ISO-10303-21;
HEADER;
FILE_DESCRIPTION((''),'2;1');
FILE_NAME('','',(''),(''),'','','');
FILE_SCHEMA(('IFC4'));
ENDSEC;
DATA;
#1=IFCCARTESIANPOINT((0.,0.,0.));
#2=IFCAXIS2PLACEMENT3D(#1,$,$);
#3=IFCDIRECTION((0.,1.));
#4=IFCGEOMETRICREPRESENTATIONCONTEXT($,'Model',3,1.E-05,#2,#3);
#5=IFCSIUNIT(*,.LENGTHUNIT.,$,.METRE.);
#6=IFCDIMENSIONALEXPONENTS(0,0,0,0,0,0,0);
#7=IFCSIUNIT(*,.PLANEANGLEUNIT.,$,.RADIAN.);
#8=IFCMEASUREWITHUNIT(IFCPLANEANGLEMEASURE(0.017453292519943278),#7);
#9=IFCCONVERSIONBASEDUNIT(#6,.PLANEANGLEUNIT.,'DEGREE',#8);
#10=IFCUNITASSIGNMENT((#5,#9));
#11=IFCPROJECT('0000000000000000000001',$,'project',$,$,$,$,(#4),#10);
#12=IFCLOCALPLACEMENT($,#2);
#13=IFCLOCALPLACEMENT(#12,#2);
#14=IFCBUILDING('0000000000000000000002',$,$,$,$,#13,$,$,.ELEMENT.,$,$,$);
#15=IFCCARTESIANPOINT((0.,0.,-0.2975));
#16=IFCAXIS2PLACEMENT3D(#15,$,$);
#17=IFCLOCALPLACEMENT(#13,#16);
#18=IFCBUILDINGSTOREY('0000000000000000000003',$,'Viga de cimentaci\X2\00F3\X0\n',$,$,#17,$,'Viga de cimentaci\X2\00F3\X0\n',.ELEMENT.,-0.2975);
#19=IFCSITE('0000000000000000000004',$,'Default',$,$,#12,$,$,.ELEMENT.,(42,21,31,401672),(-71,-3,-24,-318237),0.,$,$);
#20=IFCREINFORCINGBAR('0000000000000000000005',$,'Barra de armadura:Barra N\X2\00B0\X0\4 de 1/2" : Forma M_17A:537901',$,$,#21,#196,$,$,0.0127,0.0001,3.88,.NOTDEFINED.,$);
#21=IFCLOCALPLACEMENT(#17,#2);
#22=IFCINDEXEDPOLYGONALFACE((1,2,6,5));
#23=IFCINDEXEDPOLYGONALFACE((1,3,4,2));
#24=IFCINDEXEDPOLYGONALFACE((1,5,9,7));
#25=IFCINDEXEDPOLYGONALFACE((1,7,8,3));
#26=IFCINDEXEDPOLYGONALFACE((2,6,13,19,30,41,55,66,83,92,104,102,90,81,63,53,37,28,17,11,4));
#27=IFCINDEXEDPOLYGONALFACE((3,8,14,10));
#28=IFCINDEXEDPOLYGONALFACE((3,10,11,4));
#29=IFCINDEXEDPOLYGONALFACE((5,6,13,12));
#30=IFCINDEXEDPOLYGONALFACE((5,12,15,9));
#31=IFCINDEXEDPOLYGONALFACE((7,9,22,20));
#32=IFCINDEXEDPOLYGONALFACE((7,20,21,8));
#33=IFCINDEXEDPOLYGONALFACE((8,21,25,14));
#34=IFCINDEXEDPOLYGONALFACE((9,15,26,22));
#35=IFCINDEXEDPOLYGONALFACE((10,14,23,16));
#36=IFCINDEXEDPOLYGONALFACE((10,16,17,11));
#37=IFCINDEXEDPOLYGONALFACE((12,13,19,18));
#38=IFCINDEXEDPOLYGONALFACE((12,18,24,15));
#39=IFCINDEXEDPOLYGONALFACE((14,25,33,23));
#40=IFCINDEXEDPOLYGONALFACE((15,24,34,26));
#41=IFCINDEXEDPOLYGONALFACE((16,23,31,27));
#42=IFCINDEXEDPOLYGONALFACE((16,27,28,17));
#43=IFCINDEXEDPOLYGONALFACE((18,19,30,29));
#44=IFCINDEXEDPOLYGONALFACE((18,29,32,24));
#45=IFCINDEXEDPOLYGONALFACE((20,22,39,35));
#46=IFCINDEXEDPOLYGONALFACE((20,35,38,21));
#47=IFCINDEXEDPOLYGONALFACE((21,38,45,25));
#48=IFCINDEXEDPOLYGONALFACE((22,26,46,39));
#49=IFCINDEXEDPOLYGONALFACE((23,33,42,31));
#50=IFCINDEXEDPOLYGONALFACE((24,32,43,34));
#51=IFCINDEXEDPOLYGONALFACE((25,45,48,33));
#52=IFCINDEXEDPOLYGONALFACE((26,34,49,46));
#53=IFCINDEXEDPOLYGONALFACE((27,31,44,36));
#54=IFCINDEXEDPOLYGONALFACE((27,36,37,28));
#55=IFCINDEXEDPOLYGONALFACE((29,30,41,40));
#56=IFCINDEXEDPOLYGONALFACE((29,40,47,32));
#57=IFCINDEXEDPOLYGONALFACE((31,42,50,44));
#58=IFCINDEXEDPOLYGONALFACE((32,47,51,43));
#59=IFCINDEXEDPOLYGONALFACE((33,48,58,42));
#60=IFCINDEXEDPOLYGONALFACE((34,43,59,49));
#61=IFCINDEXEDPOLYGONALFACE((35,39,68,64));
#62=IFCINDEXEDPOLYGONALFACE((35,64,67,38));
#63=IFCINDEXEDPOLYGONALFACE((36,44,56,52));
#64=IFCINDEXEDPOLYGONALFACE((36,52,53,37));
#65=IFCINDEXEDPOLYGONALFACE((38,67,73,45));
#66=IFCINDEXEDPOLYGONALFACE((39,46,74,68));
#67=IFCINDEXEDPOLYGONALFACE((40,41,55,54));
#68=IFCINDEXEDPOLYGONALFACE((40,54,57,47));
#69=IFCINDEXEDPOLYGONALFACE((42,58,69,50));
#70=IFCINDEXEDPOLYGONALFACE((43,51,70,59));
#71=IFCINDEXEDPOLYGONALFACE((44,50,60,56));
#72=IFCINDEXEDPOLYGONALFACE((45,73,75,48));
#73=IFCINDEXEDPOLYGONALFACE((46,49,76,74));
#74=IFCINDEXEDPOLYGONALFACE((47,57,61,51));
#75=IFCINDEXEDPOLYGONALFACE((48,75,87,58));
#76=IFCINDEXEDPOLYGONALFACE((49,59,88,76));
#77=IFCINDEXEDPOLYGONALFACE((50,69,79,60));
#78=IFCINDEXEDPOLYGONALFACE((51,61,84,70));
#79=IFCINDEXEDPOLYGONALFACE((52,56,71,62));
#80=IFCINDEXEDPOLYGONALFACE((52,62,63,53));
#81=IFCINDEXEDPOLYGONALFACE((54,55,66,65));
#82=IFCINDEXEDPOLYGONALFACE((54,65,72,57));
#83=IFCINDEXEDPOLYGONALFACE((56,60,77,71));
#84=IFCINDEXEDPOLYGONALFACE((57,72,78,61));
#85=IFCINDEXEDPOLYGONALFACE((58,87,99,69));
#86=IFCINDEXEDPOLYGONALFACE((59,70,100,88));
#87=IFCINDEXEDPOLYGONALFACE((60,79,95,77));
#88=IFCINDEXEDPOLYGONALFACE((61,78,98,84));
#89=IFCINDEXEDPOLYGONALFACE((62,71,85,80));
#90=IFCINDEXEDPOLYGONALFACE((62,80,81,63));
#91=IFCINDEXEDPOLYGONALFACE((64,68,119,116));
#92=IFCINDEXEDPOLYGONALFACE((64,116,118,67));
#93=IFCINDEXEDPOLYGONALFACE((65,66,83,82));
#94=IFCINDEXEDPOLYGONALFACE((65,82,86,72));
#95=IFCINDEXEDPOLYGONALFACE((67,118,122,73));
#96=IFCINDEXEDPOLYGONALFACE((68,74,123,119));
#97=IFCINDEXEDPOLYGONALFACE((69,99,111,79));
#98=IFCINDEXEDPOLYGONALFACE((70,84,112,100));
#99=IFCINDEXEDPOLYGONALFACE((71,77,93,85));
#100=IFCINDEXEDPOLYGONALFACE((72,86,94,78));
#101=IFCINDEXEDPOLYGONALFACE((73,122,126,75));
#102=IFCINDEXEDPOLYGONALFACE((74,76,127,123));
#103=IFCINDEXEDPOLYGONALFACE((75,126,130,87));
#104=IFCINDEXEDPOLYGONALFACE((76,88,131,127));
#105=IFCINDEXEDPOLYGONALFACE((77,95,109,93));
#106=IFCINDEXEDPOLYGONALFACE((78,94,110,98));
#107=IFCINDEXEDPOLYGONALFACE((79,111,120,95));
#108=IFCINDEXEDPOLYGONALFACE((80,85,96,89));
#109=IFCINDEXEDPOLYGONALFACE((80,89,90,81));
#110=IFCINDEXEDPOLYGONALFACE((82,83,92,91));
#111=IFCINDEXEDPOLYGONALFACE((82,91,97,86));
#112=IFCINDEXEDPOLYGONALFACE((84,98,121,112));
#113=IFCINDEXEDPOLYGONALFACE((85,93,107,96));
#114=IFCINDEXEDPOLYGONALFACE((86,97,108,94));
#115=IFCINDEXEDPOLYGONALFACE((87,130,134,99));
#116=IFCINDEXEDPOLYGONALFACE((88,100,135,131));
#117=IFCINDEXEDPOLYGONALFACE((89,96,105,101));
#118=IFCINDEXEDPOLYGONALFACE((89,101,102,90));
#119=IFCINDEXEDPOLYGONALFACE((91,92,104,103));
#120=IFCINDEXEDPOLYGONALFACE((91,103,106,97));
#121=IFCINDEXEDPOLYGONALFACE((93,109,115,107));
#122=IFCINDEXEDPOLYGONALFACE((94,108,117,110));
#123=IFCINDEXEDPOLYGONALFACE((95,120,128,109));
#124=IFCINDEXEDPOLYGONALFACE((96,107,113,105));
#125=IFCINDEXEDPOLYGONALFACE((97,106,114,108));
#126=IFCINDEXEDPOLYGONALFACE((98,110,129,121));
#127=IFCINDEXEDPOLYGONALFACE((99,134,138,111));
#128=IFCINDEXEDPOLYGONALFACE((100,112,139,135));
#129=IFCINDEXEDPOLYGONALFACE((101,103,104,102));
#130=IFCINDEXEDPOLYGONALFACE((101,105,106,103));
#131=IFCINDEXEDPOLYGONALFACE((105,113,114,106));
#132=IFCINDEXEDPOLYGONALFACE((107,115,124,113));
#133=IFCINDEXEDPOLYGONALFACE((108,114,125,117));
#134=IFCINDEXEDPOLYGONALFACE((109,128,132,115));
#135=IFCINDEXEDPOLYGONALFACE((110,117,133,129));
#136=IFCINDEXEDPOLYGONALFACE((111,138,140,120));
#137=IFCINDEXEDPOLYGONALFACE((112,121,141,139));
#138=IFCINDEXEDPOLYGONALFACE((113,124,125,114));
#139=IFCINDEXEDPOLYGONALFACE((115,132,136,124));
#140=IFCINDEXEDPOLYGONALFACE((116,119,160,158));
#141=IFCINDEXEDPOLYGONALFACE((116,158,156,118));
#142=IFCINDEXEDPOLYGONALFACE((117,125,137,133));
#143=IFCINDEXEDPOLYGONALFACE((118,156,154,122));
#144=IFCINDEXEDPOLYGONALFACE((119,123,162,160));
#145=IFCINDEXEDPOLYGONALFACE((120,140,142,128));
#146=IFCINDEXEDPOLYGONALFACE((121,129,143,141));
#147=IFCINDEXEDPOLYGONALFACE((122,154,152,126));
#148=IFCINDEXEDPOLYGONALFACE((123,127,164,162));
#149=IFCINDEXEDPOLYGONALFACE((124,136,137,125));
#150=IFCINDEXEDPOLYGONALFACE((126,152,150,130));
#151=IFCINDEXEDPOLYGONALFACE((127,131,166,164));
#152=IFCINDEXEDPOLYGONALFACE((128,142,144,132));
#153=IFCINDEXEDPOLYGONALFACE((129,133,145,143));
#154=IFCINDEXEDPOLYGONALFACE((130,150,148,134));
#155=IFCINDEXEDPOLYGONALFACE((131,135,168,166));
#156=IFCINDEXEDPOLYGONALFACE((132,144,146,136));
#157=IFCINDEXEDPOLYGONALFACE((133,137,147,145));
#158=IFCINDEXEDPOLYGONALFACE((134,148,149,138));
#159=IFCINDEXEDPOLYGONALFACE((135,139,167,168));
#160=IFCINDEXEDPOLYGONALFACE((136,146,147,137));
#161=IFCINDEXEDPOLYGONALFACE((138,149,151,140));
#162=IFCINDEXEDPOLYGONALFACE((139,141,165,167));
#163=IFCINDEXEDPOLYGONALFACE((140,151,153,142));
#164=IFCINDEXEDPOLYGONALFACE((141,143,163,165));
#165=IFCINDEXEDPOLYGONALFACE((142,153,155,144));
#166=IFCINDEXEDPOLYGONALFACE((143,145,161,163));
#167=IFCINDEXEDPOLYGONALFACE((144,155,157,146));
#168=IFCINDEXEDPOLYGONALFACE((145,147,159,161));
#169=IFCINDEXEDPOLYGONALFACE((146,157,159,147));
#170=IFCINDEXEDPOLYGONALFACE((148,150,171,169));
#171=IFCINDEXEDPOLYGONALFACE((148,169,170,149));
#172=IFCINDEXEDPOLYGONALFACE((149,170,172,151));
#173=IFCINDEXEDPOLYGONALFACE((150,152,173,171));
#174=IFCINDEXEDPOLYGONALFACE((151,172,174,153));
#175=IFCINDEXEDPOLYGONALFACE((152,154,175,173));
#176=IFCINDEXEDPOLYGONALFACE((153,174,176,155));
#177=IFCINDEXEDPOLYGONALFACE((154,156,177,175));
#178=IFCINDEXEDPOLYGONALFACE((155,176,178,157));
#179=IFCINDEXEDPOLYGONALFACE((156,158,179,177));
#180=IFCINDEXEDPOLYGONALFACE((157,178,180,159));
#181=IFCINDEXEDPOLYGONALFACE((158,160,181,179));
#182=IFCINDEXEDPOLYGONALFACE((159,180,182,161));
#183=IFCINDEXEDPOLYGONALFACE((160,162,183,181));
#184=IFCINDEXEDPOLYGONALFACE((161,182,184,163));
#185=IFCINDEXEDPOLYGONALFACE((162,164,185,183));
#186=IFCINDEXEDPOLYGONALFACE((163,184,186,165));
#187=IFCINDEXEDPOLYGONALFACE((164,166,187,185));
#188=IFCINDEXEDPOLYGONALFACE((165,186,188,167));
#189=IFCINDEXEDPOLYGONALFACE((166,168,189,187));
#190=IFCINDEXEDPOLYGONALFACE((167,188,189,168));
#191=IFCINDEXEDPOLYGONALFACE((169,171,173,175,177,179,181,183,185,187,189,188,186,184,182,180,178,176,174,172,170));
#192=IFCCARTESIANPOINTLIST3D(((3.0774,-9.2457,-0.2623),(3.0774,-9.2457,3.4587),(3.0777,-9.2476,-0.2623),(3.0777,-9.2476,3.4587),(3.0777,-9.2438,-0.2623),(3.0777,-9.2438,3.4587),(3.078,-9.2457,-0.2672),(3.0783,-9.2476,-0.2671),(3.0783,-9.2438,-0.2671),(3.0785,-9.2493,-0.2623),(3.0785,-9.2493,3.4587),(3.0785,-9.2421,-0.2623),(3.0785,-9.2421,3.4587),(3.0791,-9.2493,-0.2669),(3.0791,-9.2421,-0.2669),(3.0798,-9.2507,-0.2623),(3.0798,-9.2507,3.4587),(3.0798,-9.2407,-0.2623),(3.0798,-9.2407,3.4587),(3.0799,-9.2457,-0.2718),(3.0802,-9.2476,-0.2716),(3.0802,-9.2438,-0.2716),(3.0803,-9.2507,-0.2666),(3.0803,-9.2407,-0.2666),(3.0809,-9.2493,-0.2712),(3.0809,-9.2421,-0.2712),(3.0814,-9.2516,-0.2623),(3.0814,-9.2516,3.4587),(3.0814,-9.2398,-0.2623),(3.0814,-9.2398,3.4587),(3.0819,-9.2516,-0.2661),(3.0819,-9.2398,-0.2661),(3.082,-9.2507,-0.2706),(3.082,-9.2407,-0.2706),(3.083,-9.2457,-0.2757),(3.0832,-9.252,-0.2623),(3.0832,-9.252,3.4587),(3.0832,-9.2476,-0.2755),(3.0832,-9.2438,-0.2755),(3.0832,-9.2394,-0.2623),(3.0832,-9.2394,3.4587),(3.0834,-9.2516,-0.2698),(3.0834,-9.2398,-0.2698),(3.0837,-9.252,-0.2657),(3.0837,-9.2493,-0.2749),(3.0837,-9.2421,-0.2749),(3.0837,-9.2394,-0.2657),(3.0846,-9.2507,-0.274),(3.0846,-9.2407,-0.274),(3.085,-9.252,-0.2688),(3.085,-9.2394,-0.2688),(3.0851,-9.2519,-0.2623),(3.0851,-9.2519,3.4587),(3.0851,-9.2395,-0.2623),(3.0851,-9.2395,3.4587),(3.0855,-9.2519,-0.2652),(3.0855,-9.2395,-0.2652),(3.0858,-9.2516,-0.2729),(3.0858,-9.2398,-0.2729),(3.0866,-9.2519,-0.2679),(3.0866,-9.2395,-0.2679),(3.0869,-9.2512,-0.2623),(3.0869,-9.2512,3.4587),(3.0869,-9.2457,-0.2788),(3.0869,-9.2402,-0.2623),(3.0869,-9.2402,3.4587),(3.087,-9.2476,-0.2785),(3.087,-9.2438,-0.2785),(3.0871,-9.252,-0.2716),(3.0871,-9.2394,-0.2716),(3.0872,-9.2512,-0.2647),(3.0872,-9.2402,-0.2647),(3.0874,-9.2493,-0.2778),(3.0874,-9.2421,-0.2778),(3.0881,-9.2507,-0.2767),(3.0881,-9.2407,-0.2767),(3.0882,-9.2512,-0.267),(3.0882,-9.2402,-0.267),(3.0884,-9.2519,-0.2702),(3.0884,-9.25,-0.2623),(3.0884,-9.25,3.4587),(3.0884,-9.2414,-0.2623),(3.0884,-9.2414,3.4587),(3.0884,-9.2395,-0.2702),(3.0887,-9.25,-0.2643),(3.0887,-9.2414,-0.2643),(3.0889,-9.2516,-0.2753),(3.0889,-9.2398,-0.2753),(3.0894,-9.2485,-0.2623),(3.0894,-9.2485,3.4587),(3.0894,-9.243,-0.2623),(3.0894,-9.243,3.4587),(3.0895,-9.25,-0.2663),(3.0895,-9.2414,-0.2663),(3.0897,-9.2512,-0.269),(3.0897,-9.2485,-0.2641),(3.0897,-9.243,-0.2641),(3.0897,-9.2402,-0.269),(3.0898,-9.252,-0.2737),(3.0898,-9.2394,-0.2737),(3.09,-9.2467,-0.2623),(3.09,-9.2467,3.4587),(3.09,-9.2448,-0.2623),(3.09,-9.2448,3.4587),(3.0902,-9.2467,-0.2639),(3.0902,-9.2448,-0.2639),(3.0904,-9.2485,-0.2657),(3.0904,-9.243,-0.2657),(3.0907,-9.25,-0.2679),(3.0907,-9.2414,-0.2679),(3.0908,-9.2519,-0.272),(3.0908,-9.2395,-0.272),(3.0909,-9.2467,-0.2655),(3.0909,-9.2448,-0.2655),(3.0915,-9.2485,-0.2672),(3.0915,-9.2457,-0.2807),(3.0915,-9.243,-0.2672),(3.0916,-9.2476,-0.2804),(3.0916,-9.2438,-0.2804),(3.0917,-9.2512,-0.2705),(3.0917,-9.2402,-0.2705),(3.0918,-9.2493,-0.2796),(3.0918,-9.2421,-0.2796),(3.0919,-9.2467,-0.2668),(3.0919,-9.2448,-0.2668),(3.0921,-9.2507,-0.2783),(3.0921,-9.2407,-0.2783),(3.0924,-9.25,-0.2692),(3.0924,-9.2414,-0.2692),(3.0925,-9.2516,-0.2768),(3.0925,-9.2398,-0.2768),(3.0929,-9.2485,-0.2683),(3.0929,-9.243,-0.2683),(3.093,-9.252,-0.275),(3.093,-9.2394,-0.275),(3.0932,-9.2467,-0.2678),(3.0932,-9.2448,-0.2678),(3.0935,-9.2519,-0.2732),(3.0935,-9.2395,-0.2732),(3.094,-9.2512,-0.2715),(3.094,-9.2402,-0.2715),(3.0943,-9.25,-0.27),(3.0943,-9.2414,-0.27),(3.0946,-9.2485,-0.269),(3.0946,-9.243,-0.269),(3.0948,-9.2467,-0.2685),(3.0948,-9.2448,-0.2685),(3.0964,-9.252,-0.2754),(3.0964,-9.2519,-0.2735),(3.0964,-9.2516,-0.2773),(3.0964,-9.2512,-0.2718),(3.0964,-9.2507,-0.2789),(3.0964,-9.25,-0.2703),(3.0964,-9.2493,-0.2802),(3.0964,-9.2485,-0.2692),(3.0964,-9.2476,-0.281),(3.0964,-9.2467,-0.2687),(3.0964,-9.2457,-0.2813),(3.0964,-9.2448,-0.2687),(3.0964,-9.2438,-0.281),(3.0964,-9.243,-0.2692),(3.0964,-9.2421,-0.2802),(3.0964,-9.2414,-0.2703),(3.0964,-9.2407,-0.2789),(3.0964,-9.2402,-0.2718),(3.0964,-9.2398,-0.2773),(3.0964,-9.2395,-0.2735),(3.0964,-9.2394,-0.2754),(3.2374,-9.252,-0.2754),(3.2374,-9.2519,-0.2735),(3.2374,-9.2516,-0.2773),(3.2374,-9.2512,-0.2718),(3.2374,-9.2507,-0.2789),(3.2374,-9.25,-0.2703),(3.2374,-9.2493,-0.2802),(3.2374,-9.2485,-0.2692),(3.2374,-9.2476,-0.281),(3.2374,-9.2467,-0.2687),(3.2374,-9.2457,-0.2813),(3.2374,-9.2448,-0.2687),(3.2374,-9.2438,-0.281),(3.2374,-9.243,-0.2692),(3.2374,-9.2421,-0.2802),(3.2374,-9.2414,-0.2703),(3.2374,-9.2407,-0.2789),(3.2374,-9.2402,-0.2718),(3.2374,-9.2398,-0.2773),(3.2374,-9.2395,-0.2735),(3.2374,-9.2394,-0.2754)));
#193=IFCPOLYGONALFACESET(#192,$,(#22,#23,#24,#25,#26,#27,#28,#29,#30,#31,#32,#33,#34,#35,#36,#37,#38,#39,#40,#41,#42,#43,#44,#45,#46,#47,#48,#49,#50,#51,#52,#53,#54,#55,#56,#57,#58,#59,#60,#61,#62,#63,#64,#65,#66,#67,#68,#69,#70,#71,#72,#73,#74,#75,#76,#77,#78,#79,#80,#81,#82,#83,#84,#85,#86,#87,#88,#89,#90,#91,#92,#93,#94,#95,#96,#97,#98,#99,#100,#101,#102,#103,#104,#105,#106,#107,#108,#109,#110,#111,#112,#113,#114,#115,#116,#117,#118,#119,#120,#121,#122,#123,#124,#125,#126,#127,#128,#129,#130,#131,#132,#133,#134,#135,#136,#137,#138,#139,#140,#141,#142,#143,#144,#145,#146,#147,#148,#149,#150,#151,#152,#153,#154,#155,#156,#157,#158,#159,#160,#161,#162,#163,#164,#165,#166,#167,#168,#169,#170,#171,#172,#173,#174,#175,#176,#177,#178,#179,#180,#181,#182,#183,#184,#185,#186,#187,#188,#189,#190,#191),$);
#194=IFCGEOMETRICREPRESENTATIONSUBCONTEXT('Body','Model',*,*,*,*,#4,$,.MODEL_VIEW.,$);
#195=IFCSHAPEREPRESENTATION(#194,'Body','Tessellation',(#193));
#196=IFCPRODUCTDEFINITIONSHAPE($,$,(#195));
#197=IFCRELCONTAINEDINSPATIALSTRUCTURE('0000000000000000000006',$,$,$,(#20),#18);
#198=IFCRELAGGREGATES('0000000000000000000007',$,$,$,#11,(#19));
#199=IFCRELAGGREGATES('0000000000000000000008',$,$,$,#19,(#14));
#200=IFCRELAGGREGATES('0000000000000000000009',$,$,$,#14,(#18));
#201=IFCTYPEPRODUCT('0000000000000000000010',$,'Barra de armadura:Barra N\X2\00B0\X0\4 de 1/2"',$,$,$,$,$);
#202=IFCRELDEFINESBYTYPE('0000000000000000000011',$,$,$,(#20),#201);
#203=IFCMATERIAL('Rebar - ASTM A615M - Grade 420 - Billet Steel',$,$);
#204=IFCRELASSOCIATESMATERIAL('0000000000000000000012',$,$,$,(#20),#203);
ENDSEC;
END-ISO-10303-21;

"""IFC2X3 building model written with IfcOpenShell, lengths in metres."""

from ifc_helpers import new_model, entity, si_unit, converted_unit, direction, frame, origin, place, context, subcontext, project, spatial, material, type_object, element, save


model = new_model("IFC2X3")

# Units and contexts
model_context = context("Model", 3, precision=1e-05, world=origin(), true_north=direction((0.0, 1.0)))
body_context = subcontext(model_context, "Body", "Model", "MODEL_VIEW")
ifc_project = project(units=[si_unit("LENGTHUNIT", "METRE"), converted_unit("PLANEANGLEUNIT", "DEGREE", entity("IfcPlaneAngleMeasure", 0.017453292519943278), si_unit("PLANEANGLEUNIT", "RADIAN"), dimensions=[0, 0, 0, 0, 0, 0, 0])], contexts=[model_context])

# Site, building, storey
site_placement = place(None, origin())
site = spatial("IfcSite", under=ifc_project, at=site_placement, Name="Default", CompositionType="ELEMENT", RefLatitude=(42, 21, 31, 401672), RefLongitude=(-71, -3, -24, -318237), RefElevation=0.0)
building_placement = place(site_placement, origin())
building = spatial("IfcBuilding", under=site, at=building_placement, CompositionType="ELEMENT")
storey_placement = place(building_placement, frame((0.0, 0.0, -0.2975)))
storey = spatial("IfcBuildingStorey", under=building, at=storey_placement, Name="Viga de cimentación", LongName="Viga de cimentación", CompositionType="ELEMENT", Elevation=-0.2975)

# Reinforcing bar
ifc_material = material(Name="Rebar - ASTM A615M - Grade 420 - Billet Steel")
type_product_1 = type_object("IfcTypeProduct", Name="Barra de armadura:Barra N°4 de 1/2\"")
reinforcing_bar_1_placement = place(storey_placement, origin())
element("IfcReinforcingBar", 1, at=reinforcing_bar_1_placement, inside=storey, type_object=type_product_1, material=ifc_material, Name="Barra de armadura:Barra N°4 de 1/2\" : Forma M_17A:537901", BarLength=3.88, BarRole="NOTDEFINED", CrossSectionArea=0.0001, NominalDiameter=0.0127, context=body_context, shape_type="AdvancedSweptSolid", body=[
    entity("IfcSweptDiskSolid", entity("IfcCompositeCurve", [entity("IfcCompositeCurveSegment", "CONTINUOUS", True, entity("IfcPolyline", [entity("IfcCartesianPoint", [3.0837, -9.2457, 3.4587]), entity("IfcCartesianPoint", [3.0837, -9.2457, -0.2623])])), entity("IfcCompositeCurveSegment", "CONTINUOUS", True, entity("IfcTrimmedCurve", entity("IfcCircle", entity("IfcAxis2Placement3D", entity("IfcCartesianPoint", [3.0964, -9.2457, -0.2623]), entity("IfcDirection", [0.0, -1.0, 0.0]), entity("IfcDirection", [0.0, 0.0, -1.0])), 0.0127), [entity("IfcParameterValue", 270.0)], [entity("IfcParameterValue", 360.0)], True, "PARAMETER")), entity("IfcCompositeCurveSegment", "CONTINUOUS", True, entity("IfcPolyline", [entity("IfcCartesianPoint", [3.0964, -9.2457, -0.275]), entity("IfcCartesianPoint", [3.2374, -9.2457, -0.275])]))], False), 0.0063, None, 0.0, 92.0),
])

save(model, "model.ifc")
